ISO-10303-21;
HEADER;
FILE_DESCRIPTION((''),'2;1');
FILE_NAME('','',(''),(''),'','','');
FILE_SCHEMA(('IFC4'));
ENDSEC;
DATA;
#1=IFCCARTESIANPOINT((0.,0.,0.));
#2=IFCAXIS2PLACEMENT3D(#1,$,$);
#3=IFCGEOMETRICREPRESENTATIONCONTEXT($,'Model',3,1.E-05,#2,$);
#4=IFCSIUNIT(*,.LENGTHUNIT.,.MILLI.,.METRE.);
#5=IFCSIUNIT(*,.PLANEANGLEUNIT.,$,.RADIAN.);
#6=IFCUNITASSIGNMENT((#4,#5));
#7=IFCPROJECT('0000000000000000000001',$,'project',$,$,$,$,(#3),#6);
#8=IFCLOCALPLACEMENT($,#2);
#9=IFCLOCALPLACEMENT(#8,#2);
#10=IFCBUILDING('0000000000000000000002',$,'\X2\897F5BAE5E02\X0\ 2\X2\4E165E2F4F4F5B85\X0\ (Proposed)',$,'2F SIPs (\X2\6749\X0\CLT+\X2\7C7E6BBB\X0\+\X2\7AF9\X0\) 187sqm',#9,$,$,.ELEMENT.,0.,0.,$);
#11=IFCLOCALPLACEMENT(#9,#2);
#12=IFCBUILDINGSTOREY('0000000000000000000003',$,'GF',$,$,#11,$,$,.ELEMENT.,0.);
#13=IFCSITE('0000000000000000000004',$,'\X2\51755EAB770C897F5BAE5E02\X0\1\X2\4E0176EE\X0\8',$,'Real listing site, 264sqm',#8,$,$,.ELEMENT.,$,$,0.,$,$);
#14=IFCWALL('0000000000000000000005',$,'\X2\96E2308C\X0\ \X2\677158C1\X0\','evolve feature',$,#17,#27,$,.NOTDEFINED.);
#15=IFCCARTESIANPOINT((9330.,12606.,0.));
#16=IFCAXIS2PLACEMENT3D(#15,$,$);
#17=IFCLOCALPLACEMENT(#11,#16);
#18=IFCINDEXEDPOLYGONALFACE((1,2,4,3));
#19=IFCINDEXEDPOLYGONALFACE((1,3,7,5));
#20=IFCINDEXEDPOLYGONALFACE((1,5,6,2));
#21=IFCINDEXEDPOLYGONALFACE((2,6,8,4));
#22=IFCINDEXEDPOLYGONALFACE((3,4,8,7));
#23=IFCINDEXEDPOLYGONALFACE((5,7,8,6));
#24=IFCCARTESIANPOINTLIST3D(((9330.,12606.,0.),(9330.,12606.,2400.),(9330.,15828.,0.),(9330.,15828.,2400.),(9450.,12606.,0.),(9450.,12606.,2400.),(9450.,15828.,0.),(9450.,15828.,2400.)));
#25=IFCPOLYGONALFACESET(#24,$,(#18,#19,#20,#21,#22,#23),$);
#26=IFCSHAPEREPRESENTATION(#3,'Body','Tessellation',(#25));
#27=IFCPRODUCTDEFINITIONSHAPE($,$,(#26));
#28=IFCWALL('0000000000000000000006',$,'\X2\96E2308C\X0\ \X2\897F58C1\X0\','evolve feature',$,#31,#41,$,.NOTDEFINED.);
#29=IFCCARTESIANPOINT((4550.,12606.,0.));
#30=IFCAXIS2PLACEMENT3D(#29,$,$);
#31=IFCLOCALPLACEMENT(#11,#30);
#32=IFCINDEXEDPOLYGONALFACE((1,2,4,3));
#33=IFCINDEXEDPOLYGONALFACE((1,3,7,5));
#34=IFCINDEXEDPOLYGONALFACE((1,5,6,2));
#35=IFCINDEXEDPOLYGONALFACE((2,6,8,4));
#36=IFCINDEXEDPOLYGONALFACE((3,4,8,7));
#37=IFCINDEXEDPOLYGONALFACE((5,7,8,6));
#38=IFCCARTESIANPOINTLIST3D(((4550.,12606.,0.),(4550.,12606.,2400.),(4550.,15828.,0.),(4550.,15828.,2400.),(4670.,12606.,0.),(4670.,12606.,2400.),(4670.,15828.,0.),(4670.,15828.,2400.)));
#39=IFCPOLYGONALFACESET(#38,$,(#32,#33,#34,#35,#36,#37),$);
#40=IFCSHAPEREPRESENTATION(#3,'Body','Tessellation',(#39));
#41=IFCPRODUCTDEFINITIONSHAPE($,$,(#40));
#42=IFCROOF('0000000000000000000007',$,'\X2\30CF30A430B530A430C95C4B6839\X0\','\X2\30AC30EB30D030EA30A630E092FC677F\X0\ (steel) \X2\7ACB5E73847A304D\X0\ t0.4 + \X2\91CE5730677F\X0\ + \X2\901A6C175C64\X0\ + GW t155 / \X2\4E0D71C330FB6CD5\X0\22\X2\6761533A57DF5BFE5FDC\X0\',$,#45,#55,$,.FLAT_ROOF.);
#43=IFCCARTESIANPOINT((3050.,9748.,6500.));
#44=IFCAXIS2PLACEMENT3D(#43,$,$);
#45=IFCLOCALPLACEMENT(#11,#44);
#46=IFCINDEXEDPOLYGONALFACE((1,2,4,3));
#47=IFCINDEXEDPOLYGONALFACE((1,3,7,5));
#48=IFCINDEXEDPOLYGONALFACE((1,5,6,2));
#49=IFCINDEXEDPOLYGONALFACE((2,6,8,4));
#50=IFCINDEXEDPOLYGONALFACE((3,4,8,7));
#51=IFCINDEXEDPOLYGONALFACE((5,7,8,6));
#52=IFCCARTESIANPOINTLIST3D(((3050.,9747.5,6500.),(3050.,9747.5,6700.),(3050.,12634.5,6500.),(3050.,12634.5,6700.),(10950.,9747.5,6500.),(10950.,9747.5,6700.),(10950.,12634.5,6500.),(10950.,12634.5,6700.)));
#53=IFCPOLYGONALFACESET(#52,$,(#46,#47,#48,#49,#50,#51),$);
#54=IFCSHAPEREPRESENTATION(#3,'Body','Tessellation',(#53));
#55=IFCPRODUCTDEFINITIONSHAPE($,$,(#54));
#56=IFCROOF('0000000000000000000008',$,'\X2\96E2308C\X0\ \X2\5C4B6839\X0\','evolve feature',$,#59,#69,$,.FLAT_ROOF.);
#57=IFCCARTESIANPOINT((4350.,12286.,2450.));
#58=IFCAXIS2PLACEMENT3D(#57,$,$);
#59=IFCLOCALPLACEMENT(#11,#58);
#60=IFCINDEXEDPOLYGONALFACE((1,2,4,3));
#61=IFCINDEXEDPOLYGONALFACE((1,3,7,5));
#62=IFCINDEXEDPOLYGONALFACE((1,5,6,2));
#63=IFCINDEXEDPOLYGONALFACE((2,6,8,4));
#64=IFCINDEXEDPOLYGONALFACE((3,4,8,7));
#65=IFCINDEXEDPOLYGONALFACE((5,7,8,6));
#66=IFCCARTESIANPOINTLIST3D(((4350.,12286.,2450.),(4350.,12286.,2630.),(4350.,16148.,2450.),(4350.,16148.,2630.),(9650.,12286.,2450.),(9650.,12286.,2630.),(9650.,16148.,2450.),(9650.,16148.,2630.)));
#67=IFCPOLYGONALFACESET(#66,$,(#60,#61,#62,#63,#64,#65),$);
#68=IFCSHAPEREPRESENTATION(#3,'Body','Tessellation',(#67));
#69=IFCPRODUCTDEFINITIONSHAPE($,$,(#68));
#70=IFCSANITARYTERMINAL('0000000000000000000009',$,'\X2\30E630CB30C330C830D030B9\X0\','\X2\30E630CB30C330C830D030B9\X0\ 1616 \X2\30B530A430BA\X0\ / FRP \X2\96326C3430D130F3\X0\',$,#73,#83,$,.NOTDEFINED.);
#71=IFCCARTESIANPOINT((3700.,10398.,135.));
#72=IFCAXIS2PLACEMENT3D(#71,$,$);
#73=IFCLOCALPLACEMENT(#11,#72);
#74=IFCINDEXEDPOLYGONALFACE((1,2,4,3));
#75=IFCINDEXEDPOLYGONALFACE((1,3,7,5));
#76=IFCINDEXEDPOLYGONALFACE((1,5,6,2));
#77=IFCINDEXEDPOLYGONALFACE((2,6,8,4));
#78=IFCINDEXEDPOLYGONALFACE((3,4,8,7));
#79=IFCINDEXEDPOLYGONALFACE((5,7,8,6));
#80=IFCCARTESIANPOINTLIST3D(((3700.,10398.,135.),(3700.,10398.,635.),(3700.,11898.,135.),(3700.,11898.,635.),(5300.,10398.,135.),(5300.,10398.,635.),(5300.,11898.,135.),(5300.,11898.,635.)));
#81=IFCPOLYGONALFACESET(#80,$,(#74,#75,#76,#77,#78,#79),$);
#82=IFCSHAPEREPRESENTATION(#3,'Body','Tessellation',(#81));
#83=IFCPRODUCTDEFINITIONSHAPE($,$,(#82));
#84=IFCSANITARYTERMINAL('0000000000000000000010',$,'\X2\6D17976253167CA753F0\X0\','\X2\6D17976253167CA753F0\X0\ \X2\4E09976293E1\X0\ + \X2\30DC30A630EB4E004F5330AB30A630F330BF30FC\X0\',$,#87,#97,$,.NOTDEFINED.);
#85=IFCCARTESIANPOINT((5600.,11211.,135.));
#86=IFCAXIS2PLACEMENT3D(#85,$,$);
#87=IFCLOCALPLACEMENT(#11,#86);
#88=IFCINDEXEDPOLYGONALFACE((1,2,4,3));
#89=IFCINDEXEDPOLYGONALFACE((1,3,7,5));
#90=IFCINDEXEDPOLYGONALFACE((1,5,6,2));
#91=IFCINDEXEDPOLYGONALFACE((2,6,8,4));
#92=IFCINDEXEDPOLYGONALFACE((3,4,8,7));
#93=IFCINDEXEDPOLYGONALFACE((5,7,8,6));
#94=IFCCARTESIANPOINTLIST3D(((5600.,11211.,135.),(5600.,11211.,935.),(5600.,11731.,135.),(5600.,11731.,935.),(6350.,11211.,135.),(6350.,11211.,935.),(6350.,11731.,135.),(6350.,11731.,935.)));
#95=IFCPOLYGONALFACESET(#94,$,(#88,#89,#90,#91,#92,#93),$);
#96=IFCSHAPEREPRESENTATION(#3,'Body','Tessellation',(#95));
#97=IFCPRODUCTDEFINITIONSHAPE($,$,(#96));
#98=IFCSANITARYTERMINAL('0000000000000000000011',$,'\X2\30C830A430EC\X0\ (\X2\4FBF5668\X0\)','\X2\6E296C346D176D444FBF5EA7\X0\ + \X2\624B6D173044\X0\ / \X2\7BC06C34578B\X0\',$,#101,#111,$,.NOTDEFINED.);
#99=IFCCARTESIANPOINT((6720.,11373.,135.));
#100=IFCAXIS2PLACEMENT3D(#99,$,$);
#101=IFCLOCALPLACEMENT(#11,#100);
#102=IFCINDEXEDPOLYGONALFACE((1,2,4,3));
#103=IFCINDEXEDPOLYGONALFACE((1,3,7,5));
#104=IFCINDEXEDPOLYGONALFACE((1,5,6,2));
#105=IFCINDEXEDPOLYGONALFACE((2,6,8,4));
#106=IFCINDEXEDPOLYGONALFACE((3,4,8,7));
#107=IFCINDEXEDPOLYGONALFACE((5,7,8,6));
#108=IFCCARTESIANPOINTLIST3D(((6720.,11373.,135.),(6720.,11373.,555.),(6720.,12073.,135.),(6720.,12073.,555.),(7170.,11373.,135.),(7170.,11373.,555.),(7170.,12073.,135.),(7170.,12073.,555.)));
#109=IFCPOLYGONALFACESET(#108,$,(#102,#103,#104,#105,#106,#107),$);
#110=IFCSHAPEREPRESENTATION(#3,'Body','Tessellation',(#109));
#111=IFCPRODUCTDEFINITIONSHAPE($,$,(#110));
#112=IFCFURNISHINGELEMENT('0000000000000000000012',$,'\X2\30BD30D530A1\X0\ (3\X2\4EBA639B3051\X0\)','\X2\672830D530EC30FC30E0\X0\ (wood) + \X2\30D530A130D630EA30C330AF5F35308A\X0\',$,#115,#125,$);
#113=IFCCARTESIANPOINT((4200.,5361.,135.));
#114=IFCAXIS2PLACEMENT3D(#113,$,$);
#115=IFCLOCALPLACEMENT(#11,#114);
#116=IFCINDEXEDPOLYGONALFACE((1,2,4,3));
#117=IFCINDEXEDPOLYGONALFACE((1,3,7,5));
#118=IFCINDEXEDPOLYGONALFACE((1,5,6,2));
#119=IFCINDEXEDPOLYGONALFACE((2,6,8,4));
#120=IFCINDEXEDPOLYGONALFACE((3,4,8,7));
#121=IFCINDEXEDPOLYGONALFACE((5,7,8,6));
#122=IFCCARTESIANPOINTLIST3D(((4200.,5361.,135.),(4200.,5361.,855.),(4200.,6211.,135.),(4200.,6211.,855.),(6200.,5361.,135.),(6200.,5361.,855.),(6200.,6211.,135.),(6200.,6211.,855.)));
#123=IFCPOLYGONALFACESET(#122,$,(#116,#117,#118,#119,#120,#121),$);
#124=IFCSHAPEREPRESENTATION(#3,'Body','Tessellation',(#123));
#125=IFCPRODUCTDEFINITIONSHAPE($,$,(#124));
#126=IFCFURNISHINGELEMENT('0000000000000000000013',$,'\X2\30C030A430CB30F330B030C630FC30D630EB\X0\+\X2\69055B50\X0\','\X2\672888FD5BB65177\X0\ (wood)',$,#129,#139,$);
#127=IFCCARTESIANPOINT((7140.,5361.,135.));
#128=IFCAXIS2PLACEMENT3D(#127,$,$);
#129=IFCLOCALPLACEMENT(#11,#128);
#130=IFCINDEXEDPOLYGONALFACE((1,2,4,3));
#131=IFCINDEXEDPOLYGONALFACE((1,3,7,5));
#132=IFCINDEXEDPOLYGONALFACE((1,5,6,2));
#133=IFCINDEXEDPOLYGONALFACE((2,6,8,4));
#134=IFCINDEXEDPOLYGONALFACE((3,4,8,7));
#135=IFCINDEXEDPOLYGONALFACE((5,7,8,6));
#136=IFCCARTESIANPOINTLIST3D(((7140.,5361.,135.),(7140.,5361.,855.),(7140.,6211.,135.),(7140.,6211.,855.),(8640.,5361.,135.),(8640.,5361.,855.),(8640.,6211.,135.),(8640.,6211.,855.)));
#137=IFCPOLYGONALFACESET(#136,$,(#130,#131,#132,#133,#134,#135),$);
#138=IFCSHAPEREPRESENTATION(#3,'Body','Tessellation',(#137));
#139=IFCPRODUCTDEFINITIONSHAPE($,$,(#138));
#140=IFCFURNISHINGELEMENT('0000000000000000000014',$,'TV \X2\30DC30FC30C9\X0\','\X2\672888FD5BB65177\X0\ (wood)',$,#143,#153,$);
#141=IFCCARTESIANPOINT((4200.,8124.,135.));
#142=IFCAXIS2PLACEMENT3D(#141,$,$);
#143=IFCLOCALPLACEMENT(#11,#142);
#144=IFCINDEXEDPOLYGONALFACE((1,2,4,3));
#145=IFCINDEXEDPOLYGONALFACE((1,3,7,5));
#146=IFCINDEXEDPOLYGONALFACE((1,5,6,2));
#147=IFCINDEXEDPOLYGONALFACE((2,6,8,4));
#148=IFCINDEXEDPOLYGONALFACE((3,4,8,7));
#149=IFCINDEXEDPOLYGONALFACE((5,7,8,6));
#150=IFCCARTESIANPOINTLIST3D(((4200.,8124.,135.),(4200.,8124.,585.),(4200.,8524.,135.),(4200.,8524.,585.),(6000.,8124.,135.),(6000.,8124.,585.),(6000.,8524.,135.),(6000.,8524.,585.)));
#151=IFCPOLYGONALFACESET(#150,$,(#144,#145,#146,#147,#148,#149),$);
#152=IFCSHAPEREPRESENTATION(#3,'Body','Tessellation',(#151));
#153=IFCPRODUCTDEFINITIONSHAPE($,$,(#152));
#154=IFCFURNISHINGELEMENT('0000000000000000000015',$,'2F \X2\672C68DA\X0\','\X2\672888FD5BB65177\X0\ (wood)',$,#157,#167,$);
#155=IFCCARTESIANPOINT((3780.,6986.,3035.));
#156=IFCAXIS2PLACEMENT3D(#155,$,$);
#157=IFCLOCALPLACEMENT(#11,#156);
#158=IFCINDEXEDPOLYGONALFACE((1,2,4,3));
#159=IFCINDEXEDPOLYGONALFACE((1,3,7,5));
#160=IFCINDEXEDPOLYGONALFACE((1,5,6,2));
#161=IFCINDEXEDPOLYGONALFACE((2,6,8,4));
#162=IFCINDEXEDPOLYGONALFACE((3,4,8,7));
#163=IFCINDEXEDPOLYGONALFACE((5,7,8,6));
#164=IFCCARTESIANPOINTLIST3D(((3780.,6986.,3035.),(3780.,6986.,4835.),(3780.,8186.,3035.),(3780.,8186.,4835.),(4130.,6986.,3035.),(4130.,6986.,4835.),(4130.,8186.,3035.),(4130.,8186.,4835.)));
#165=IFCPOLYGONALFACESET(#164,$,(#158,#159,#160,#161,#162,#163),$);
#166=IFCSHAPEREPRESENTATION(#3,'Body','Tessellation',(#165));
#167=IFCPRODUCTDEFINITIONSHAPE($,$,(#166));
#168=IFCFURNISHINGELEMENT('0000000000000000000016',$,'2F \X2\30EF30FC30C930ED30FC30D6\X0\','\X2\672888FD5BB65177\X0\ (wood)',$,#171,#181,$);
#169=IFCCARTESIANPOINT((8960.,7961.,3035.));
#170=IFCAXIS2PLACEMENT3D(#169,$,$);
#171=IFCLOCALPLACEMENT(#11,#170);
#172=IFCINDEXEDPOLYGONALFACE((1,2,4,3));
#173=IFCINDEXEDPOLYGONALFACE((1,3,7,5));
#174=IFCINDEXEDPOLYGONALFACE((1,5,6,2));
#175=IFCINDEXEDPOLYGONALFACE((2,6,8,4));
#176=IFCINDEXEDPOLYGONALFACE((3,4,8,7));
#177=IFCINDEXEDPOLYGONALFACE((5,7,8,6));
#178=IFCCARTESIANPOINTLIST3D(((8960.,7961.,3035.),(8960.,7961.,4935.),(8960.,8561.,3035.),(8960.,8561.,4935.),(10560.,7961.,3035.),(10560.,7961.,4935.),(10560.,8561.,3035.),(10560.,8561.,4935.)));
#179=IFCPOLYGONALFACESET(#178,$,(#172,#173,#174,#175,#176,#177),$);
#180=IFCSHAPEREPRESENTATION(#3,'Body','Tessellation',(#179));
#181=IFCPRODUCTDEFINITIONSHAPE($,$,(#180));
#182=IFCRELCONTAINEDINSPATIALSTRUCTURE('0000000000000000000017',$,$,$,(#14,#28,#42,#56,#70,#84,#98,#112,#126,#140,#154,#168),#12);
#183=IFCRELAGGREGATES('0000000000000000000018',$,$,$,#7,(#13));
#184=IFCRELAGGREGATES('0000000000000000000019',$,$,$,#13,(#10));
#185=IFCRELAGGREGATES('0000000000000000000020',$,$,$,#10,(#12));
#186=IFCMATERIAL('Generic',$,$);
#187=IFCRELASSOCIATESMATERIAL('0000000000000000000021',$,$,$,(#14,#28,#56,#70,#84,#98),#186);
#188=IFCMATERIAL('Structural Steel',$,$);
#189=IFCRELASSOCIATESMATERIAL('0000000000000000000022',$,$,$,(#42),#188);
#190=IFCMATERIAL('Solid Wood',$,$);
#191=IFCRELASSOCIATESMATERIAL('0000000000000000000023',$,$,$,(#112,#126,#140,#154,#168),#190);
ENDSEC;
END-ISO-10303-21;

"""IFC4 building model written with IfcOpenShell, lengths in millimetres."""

from ifc_helpers import new_model, si_unit, frame, frame_2d, origin, place, context, project, spatial, rectangle, extrude, material, element, save


model = new_model("IFC4")

# Units and contexts
model_context = context("Model", 3, precision=1e-05, world=origin())
ifc_project = project(units=[si_unit("LENGTHUNIT", "METRE", prefix="MILLI"), si_unit("PLANEANGLEUNIT", "RADIAN")], contexts=[model_context])

# Site, building, storey
site_placement = place(None, origin())
site = spatial("IfcSite", under=ifc_project, at=site_placement, Name="兵庫県西宮市1丁目8", ObjectType="Real listing site, 264sqm", CompositionType="ELEMENT", RefElevation=0.0)
building_placement = place(site_placement, origin())
building = spatial("IfcBuilding", under=site, at=building_placement, Name="西宮市 2世帯住宅 (Proposed)", ObjectType="2F SIPs (杉CLT+籾殻+竹) 187sqm", CompositionType="ELEMENT", ElevationOfRefHeight=0.0, ElevationOfTerrain=0.0)
storey_placement = place(building_placement, origin())
storey = spatial("IfcBuildingStorey", under=building, at=storey_placement, Name="GF", CompositionType="ELEMENT", Elevation=0.0)

# Shared definitions
ifc_material_1 = material(Name="Generic")

# Shared definitions
ifc_material_2 = material(Name="Solid Wood")

# Walls
wall_1_placement = place(storey_placement, frame((9330.0, 12606.0, 0.0)))
element("IfcWall", 1, at=wall_1_placement, inside=storey, material=ifc_material_1, Name="離れ 東壁", Description="evolve feature", PredefinedType="NOTDEFINED", context=model_context, shape_type="SweptSolid", body=[
    extrude(rectangle(XDim=120.0, YDim=3222.0, at=frame_2d((60.0, 1611.0))), frame((9330.0, 12606.0, 0.0)), (0.0, 0.0, 1.0), 2400.0),
])
wall_2_placement = place(storey_placement, frame((4550.0, 12606.0, 0.0)))
element("IfcWall", 2, at=wall_2_placement, inside=storey, material=ifc_material_1, Name="離れ 西壁", Description="evolve feature", PredefinedType="NOTDEFINED", context=model_context, shape_type="SweptSolid", body=[
    extrude(rectangle(XDim=120.0, YDim=3222.0, at=frame_2d((60.0, 1611.0))), frame((4550.0, 12606.0, 0.0)), (0.0, 0.0, 1.0), 2400.0),
])

# Roofs
ifc_material_3 = material(Name="Structural Steel")
roof_1_placement = place(storey_placement, frame((3050.0, 9748.0, 6500.0)))
element("IfcRoof", 3, at=roof_1_placement, inside=storey, material=ifc_material_3, Name="ハイサイド屋根", Description="ガルバリウム鋼板 (steel) 立平葺き t0.4 + 野地板 + 通気層 + GW t155 / 不燃・法22条区域対応", PredefinedType="FLAT_ROOF", context=model_context, shape_type="SweptSolid", body=[
    extrude(rectangle(XDim=7900.0, YDim=2887.0, at=frame_2d((3950.0, 1443.0))), frame((3050.0, 9748.0, 6500.0)), (0.0, 0.0, 1.0), 200.0),
])
roof_2_placement = place(storey_placement, frame((4350.0, 12286.0, 2450.0)))
element("IfcRoof", 4, at=roof_2_placement, inside=storey, material=ifc_material_1, Name="離れ 屋根", Description="evolve feature", PredefinedType="FLAT_ROOF", context=model_context, shape_type="SweptSolid", body=[
    extrude(rectangle(XDim=5300.0, YDim=3862.0, at=frame_2d((2650.0, 1931.0))), frame((4350.0, 12286.0, 2450.0)), (0.0, 0.0, 1.0), 180.0),
])

# Sanitary terminals
sanitary_terminal_1_placement = place(storey_placement, frame((3700.0, 10398.0, 135.0)))
element("IfcSanitaryTerminal", 5, at=sanitary_terminal_1_placement, inside=storey, material=ifc_material_1, Name="ユニットバス", Description="ユニットバス 1616 サイズ / FRP 防水パン", PredefinedType="NOTDEFINED", context=model_context, shape_type="SweptSolid", body=[
    extrude(rectangle(XDim=1600.0, YDim=1500.0, at=frame_2d((800.0, 750.0))), frame((3700.0, 10398.0, 135.0)), (0.0, 0.0, 1.0), 500.0),
])
sanitary_terminal_2_placement = place(storey_placement, frame((5600.0, 11211.0, 135.0)))
element("IfcSanitaryTerminal", 6, at=sanitary_terminal_2_placement, inside=storey, material=ifc_material_1, Name="洗面化粧台", Description="洗面化粧台 三面鏡 + ボウル一体カウンター", PredefinedType="NOTDEFINED", context=model_context, shape_type="SweptSolid", body=[
    extrude(rectangle(XDim=750.0, YDim=520.0, at=frame_2d((375.0, 260.0))), frame((5600.0, 11211.0, 135.0)), (0.0, 0.0, 1.0), 800.0),
])
sanitary_terminal_3_placement = place(storey_placement, frame((6720.0, 11373.0, 135.0)))
element("IfcSanitaryTerminal", 7, at=sanitary_terminal_3_placement, inside=storey, material=ifc_material_1, Name="トイレ (便器)", Description="温水洗浄便座 + 手洗い / 節水型", PredefinedType="NOTDEFINED", context=model_context, shape_type="SweptSolid", body=[
    extrude(rectangle(XDim=450.0, YDim=700.0, at=frame_2d((225.0, 350.0))), frame((6720.0, 11373.0, 135.0)), (0.0, 0.0, 1.0), 420.0),
])

# Furnishing elements
furnishing_1_placement = place(storey_placement, frame((4200.0, 5361.0, 135.0)))
element("IfcFurnishingElement", 8, at=furnishing_1_placement, inside=storey, material=ifc_material_2, Name="ソファ (3人掛け)", Description="木フレーム (wood) + ファブリック張り", context=model_context, shape_type="SweptSolid", body=[
    extrude(rectangle(XDim=2000.0, YDim=850.0, at=frame_2d((1000.0, 425.0))), frame((4200.0, 5361.0, 135.0)), (0.0, 0.0, 1.0), 720.0),
])
furnishing_2_placement = place(storey_placement, frame((7140.0, 5361.0, 135.0)))
element("IfcFurnishingElement", 9, at=furnishing_2_placement, inside=storey, material=ifc_material_2, Name="ダイニングテーブル+椅子", Description="木製家具 (wood)", context=model_context, shape_type="SweptSolid", body=[
    extrude(rectangle(XDim=1500.0, YDim=850.0, at=frame_2d((750.0, 425.0))), frame((7140.0, 5361.0, 135.0)), (0.0, 0.0, 1.0), 720.0),
])
furnishing_3_placement = place(storey_placement, frame((4200.0, 8124.0, 135.0)))
element("IfcFurnishingElement", 10, at=furnishing_3_placement, inside=storey, material=ifc_material_2, Name="TV ボード", Description="木製家具 (wood)", context=model_context, shape_type="SweptSolid", body=[
    extrude(rectangle(XDim=1800.0, YDim=400.0, at=frame_2d((900.0, 200.0))), frame((4200.0, 8124.0, 135.0)), (0.0, 0.0, 1.0), 450.0),
])
furnishing_4_placement = place(storey_placement, frame((3780.0, 6986.0, 3035.0)))
element("IfcFurnishingElement", 11, at=furnishing_4_placement, inside=storey, material=ifc_material_2, Name="2F 本棚", Description="木製家具 (wood)", context=model_context, shape_type="SweptSolid", body=[
    extrude(rectangle(XDim=350.0, YDim=1200.0, at=frame_2d((175.0, 600.0))), frame((3780.0, 6986.0, 3035.0)), (0.0, 0.0, 1.0), 1800.0),
])
furnishing_5_placement = place(storey_placement, frame((8960.0, 7961.0, 3035.0)))
element("IfcFurnishingElement", 12, at=furnishing_5_placement, inside=storey, material=ifc_material_2, Name="2F ワードローブ", Description="木製家具 (wood)", context=model_context, shape_type="SweptSolid", body=[
    extrude(rectangle(XDim=1600.0, YDim=600.0, at=frame_2d((800.0, 300.0))), frame((8960.0, 7961.0, 3035.0)), (0.0, 0.0, 1.0), 1900.0),
])

save(model, "model.ifc")
